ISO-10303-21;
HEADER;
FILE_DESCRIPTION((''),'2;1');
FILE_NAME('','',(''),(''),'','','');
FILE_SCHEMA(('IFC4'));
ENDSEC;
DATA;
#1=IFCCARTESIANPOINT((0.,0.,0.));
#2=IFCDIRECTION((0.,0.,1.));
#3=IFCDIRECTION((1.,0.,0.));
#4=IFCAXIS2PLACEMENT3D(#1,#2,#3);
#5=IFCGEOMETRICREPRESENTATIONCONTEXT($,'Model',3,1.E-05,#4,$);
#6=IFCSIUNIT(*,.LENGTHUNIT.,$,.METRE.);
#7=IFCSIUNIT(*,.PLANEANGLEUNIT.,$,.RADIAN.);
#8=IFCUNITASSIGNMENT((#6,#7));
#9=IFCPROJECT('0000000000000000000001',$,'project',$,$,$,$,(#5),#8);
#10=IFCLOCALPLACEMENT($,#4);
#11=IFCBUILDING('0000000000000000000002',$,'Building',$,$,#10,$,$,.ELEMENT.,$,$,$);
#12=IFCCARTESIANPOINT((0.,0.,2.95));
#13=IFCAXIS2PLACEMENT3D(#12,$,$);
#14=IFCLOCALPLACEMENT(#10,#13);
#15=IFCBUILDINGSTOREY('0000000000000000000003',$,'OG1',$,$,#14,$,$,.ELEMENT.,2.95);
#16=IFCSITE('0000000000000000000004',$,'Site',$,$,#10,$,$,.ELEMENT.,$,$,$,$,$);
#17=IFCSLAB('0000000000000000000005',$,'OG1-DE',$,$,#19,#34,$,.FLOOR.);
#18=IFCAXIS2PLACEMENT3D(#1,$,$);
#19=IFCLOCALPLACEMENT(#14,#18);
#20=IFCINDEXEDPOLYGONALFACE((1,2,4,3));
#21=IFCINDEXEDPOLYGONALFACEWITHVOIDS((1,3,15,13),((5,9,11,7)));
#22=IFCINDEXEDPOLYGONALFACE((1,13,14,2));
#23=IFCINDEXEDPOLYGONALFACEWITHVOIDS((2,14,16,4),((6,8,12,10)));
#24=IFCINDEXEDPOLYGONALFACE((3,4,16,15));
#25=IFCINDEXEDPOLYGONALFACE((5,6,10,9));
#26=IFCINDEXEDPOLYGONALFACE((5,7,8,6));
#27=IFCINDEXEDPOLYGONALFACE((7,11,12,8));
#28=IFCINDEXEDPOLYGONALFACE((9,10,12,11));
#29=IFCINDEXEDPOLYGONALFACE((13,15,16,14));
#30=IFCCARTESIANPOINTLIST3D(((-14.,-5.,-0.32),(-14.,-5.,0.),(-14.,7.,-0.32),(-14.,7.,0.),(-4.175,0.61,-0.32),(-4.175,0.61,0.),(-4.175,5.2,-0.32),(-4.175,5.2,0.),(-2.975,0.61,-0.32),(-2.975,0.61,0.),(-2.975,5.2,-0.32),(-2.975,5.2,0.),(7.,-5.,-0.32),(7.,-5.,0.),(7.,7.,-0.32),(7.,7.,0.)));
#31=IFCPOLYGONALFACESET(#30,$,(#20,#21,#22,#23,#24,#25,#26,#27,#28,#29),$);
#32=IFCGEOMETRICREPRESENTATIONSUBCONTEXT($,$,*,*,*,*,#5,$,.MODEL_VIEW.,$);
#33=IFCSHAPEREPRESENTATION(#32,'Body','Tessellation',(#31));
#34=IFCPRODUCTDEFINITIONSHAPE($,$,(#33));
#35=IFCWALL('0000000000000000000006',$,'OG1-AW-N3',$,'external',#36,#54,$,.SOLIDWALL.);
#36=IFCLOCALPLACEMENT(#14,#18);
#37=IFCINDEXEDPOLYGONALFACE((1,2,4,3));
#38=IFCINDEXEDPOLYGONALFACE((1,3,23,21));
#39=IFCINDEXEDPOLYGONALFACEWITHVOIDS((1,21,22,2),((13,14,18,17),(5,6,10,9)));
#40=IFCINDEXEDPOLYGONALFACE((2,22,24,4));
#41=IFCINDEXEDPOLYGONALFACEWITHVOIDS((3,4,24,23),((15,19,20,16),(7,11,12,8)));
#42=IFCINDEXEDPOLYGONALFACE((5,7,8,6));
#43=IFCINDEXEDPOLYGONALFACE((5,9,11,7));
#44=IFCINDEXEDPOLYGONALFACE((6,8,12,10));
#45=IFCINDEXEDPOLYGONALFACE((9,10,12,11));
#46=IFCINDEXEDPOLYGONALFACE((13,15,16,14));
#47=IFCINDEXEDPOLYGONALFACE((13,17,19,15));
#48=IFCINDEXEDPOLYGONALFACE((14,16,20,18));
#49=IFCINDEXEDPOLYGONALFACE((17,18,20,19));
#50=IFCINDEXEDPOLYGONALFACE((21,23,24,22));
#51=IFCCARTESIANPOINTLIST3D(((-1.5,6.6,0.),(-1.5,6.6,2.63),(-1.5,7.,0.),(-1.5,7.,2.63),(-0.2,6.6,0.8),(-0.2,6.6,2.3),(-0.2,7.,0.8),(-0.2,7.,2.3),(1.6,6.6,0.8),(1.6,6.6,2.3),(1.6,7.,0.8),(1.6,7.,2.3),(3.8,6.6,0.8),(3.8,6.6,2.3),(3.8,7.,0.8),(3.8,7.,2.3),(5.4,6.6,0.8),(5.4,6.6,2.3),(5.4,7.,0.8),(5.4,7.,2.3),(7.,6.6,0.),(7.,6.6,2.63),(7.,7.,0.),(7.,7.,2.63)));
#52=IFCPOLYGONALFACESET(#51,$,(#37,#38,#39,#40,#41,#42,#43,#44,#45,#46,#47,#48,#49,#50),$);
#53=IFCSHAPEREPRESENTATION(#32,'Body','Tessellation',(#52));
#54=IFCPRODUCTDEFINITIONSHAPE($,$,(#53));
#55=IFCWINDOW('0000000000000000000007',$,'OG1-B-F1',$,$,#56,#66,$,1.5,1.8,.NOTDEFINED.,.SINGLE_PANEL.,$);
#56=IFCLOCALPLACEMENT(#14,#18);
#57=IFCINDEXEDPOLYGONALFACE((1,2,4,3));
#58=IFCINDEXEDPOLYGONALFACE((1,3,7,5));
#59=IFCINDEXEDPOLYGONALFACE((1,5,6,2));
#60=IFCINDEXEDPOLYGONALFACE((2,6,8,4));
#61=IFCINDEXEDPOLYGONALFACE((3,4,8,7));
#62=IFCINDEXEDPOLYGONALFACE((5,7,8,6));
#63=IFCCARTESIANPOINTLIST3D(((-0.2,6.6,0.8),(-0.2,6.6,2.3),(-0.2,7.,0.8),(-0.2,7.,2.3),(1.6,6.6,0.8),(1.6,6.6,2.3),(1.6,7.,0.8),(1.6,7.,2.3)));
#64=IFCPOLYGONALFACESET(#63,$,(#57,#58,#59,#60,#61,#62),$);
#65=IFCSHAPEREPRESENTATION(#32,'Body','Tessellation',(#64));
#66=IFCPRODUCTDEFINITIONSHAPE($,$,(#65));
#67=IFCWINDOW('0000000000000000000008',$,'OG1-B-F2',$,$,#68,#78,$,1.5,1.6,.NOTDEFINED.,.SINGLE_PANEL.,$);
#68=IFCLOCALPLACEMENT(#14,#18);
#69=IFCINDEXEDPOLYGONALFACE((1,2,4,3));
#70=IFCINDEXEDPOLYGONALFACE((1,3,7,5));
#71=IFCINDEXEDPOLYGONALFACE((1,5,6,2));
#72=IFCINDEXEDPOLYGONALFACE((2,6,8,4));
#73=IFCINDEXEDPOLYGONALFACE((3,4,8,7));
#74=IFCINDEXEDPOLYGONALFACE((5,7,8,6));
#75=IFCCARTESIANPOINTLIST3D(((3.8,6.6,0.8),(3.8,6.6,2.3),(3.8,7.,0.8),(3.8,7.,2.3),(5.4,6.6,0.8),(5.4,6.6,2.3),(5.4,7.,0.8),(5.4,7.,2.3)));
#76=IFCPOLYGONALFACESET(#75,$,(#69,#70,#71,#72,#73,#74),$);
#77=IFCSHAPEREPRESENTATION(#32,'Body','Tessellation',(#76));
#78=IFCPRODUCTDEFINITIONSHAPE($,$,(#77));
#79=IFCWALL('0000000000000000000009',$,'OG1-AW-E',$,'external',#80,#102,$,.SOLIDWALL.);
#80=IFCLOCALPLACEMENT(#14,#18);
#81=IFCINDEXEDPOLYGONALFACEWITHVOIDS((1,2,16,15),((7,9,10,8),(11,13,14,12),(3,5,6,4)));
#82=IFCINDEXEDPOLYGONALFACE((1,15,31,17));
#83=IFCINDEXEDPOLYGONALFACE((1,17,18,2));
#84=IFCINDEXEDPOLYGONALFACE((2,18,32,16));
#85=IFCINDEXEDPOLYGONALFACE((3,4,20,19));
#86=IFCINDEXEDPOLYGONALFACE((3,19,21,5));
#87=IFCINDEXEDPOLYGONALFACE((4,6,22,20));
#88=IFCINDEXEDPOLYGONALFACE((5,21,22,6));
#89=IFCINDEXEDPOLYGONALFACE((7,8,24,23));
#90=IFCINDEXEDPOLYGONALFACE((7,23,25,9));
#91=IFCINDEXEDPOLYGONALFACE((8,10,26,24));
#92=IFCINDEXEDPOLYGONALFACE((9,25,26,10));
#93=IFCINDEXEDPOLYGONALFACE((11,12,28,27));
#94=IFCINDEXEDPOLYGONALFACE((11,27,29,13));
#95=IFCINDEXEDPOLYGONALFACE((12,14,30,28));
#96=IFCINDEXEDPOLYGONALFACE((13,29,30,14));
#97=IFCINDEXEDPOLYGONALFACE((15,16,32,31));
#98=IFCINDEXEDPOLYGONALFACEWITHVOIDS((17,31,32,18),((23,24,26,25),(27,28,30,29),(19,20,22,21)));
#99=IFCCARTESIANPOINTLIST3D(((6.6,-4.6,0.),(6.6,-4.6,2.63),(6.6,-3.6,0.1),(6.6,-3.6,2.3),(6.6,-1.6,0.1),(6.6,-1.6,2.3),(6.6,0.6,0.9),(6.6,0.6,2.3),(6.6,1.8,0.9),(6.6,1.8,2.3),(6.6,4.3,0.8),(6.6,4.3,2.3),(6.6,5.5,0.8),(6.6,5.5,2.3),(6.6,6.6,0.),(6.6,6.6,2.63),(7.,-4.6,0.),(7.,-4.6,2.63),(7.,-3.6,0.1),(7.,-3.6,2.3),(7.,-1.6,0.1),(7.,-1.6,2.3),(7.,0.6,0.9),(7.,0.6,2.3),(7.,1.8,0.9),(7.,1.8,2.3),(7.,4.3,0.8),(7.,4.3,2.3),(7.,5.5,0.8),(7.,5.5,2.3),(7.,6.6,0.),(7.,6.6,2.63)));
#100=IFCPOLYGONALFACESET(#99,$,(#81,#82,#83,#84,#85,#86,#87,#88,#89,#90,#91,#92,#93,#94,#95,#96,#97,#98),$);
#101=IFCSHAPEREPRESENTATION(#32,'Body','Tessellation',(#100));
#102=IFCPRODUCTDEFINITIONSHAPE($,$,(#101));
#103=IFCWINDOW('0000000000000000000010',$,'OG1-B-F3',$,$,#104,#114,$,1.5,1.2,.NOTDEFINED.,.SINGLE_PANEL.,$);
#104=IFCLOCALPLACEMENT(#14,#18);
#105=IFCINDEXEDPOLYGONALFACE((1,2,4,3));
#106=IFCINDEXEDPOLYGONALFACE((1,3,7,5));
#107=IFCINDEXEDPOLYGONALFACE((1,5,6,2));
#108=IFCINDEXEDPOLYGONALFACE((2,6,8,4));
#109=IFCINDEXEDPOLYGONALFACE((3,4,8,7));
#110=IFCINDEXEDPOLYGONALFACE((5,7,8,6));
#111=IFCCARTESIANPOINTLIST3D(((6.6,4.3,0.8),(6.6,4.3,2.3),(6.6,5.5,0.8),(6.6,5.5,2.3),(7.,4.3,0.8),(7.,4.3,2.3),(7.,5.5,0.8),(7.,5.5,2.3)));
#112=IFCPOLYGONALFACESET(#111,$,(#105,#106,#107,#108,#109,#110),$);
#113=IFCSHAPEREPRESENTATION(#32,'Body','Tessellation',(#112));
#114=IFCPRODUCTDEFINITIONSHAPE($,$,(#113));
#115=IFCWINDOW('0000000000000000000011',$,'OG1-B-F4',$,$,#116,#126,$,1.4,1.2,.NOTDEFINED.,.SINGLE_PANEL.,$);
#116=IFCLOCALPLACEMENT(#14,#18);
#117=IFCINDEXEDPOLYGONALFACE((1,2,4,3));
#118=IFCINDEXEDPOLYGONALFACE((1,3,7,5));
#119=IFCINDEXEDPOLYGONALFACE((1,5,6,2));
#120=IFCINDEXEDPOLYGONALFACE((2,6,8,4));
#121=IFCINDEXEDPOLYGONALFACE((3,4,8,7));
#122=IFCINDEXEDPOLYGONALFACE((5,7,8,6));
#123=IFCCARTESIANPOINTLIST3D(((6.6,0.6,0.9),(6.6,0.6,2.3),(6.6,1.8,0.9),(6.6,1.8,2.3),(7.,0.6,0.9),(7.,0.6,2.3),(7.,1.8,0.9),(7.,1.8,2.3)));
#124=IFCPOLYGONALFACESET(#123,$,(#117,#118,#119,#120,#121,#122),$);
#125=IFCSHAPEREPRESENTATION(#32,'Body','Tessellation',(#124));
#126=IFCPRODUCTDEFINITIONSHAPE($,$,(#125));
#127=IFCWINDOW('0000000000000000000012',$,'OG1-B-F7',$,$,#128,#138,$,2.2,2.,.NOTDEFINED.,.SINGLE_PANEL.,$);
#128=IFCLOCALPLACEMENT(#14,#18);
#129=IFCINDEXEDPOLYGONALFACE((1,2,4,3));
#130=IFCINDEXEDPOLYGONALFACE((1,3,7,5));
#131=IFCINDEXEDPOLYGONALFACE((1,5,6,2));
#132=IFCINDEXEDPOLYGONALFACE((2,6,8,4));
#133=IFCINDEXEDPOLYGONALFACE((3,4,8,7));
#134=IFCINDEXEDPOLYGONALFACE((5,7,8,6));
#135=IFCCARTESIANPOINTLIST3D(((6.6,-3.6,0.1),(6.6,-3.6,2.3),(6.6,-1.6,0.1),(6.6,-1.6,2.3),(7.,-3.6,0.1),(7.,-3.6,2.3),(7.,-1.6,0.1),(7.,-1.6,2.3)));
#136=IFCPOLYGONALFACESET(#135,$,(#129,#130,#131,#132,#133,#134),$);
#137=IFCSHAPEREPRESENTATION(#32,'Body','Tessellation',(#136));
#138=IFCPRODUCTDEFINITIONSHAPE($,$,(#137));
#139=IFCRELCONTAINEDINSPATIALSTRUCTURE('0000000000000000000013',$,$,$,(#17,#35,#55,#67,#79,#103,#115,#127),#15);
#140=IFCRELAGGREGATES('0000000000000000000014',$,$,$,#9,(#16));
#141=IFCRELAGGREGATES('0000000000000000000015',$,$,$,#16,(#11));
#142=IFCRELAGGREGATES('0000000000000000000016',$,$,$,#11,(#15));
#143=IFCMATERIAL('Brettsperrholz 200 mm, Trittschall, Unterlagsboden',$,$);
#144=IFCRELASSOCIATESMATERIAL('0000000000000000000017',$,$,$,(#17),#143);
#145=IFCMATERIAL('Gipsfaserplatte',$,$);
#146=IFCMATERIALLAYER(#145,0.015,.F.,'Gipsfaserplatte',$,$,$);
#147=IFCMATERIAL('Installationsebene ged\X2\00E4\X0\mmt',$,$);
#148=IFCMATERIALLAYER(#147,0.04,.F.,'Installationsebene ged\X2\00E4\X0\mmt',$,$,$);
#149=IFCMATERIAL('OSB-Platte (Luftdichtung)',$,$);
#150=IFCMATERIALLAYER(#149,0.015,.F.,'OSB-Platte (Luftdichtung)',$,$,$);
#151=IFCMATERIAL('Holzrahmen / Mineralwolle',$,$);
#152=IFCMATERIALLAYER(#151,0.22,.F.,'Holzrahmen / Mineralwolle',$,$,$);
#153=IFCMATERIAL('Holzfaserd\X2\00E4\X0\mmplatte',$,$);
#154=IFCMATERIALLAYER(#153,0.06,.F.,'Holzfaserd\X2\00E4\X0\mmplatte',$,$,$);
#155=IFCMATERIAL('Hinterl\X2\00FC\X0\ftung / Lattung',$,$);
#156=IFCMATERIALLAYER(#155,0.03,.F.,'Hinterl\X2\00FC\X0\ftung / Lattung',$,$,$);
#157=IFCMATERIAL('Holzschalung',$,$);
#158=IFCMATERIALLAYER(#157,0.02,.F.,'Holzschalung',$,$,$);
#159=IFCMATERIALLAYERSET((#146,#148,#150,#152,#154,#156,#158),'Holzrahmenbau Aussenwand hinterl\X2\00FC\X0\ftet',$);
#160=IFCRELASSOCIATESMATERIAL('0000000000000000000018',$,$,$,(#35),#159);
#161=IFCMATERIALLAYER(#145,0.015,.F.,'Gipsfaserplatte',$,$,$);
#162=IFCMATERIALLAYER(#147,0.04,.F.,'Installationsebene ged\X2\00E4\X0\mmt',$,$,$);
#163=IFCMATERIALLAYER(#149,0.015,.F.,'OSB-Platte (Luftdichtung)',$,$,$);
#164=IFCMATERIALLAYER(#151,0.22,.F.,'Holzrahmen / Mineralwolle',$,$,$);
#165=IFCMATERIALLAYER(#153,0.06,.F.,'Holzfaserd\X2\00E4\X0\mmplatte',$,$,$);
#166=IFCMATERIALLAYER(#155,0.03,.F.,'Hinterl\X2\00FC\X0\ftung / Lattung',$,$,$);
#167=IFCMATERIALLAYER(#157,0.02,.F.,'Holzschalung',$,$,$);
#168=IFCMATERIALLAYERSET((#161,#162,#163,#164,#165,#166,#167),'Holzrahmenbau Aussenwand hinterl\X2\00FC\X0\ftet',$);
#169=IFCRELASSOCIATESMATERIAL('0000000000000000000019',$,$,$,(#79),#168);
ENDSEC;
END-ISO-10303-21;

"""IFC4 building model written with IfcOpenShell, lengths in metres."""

from ifc_helpers import new_model, si_unit, frame, frame_2d, origin, origin_with_axes, origin_2d, place, context, subcontext, project, spatial, polyline, rectangle, outline, extrude, material, layer, layer_set, element, fill, save


model = new_model("IFC4")

# Units and contexts
model_context = context("Model", 3, precision=1e-05, world=origin_with_axes())
sub_context = subcontext(model_context, None, None, "MODEL_VIEW")
ifc_project = project(units=[si_unit("LENGTHUNIT", "METRE"), si_unit("PLANEANGLEUNIT", "RADIAN")], contexts=[model_context])

# Site, building, storey
placement = place(None, origin_with_axes())
site = spatial("IfcSite", under=ifc_project, at=placement, Name="Site", CompositionType="ELEMENT")
building = spatial("IfcBuilding", under=site, at=placement, Name="Building", CompositionType="ELEMENT")
storey_placement = place(placement, frame((0.0, 0.0, 2.95)))
storey = spatial("IfcBuildingStorey", under=building, at=storey_placement, Name="OG1", CompositionType="ELEMENT", Elevation=2.95)

# Slab, opening
ifc_material_1 = material(Name="Brettsperrholz 200 mm, Trittschall, Unterlagsboden")
slab_placement = place(storey_placement, frame((0.0, 0.0, -0.32)))
slab = element("IfcSlab", 1, at=slab_placement, inside=storey, material=ifc_material_1, Name="OG1-DE", PredefinedType="FLOOR", context=sub_context, shape_type="SweptSolid", body=[
    extrude(outline(polyline([(-14.0, -5.0), (7.0, -5.0), (7.0, 7.0), (-14.0, 7.0), (-14.0, -5.0)])), origin(), (0.0, 0.0, 1.0), 0.32),
])
opening_1_placement = place(slab_placement, frame((-3.575, 2.905, 0.0)))
element("IfcOpeningElement", 2, at=opening_1_placement, cuts=slab, PredefinedType="OPENING", context=sub_context, shape_type="SweptSolid", body=[
    extrude(rectangle(XDim=1.2, YDim=4.59, at=origin_2d()), origin(), (0.0, 0.0, 1.0), 0.42),
])

# Walls, openings, windows
ifc_material_2 = material(Name="Gipsfaserplatte")
ifc_layer_1 = layer(ifc_material_2, 0.015, ventilated=False, Name="Gipsfaserplatte")
ifc_material_3 = material(Name="Installationsebene gedämmt")
ifc_layer_2 = layer(ifc_material_3, 0.04, ventilated=False, Name="Installationsebene gedämmt")
ifc_material_4 = material(Name="OSB-Platte (Luftdichtung)")
ifc_layer_3 = layer(ifc_material_4, 0.015, ventilated=False, Name="OSB-Platte (Luftdichtung)")
ifc_material_5 = material(Name="Holzrahmen / Mineralwolle")
ifc_layer_4 = layer(ifc_material_5, 0.22, ventilated=False, Name="Holzrahmen / Mineralwolle")
ifc_material_6 = material(Name="Holzfaserdämmplatte")
ifc_layer_5 = layer(ifc_material_6, 0.06, ventilated=False, Name="Holzfaserdämmplatte")
ifc_material_7 = material(Name="Hinterlüftung / Lattung")
ifc_layer_6 = layer(ifc_material_7, 0.03, ventilated=False, Name="Hinterlüftung / Lattung")
ifc_material_8 = material(Name="Holzschalung")
ifc_layer_7 = layer(ifc_material_8, 0.02, ventilated=False, Name="Holzschalung")
ifc_layer_set_1 = layer_set([ifc_layer_1, ifc_layer_2, ifc_layer_3, ifc_layer_4, ifc_layer_5, ifc_layer_6, ifc_layer_7], Name="Holzrahmenbau Aussenwand hinterlüftet")
wall_1_placement = place(storey_placement, frame((-1.5, 6.8, 0.0), z_axis=(0.0, 0.0, 1.0), x_axis=(1.0, 0.0, 0.0)))
wall_1 = element("IfcWall", 3, at=wall_1_placement, inside=storey, material=ifc_layer_set_1, Name="OG1-AW-N3", ObjectType="external", PredefinedType="SOLIDWALL", context=sub_context, shape_type="SweptSolid", body=[
    extrude(rectangle(XDim=8.5, YDim=0.4, at=frame_2d((4.25, 0.0))), origin(), (0.0, 0.0, 1.0), 2.63),
])
opening_2_placement = place(wall_1_placement, frame((2.2, 0.25, 0.8), z_axis=(0.0, -1.0, 0.0), x_axis=(1.0, 0.0, 0.0)))
opening_2 = element("IfcOpeningElement", 4, at=opening_2_placement, cuts=wall_1, PredefinedType="OPENING", context=sub_context, shape_type="SweptSolid", body=[
    extrude(rectangle(XDim=1.8, YDim=1.5, at=frame_2d((0.0, 0.75))), origin(), (0.0, 0.0, 1.0), 0.5),
])
opening_3_placement = place(wall_1_placement, frame((6.1, 0.25, 0.8), z_axis=(0.0, -1.0, 0.0), x_axis=(1.0, 0.0, 0.0)))
opening_3 = element("IfcOpeningElement", 5, at=opening_3_placement, cuts=wall_1, PredefinedType="OPENING", context=sub_context, shape_type="SweptSolid", body=[
    extrude(rectangle(XDim=1.6, YDim=1.5, at=frame_2d((0.0, 0.75))), origin(), (0.0, 0.0, 1.0), 0.5),
])
window_1_placement = place(wall_1_placement, frame((2.2, 0.2, 0.8), z_axis=(0.0, -1.0, 0.0), x_axis=(1.0, 0.0, 0.0)))
window_1 = element("IfcWindow", 6, at=window_1_placement, inside=storey, Name="OG1-B-F1", OverallHeight=1.5, OverallWidth=1.8, PartitioningType="SINGLE_PANEL", PredefinedType="NOTDEFINED", context=sub_context, shape_type="SweptSolid", body=[
    extrude(rectangle(XDim=1.8, YDim=1.5, at=frame_2d((0.0, 0.75))), origin(), (0.0, 0.0, 1.0), 0.4),
])
fill(opening_2, window_1)
window_2_placement = place(wall_1_placement, frame((6.1, 0.2, 0.8), z_axis=(0.0, -1.0, 0.0), x_axis=(1.0, 0.0, 0.0)))
window_2 = element("IfcWindow", 7, at=window_2_placement, inside=storey, Name="OG1-B-F2", OverallHeight=1.5, OverallWidth=1.6, PartitioningType="SINGLE_PANEL", PredefinedType="NOTDEFINED", context=sub_context, shape_type="SweptSolid", body=[
    extrude(rectangle(XDim=1.6, YDim=1.5, at=frame_2d((0.0, 0.75))), origin(), (0.0, 0.0, 1.0), 0.4),
])
fill(opening_3, window_2)
ifc_layer_8 = layer(ifc_material_2, 0.015, ventilated=False, Name="Gipsfaserplatte")
ifc_layer_9 = layer(ifc_material_3, 0.04, ventilated=False, Name="Installationsebene gedämmt")
ifc_layer_10 = layer(ifc_material_4, 0.015, ventilated=False, Name="OSB-Platte (Luftdichtung)")
ifc_layer_11 = layer(ifc_material_5, 0.22, ventilated=False, Name="Holzrahmen / Mineralwolle")
ifc_layer_12 = layer(ifc_material_6, 0.06, ventilated=False, Name="Holzfaserdämmplatte")
ifc_layer_13 = layer(ifc_material_7, 0.03, ventilated=False, Name="Hinterlüftung / Lattung")
ifc_layer_14 = layer(ifc_material_8, 0.02, ventilated=False, Name="Holzschalung")
ifc_layer_set_2 = layer_set([ifc_layer_8, ifc_layer_9, ifc_layer_10, ifc_layer_11, ifc_layer_12, ifc_layer_13, ifc_layer_14], Name="Holzrahmenbau Aussenwand hinterlüftet")
wall_2_placement = place(storey_placement, frame((6.8, 6.6, 0.0), z_axis=(0.0, 0.0, 1.0), x_axis=(0.0, -1.0, 0.0)))
wall_2 = element("IfcWall", 8, at=wall_2_placement, inside=storey, material=ifc_layer_set_2, Name="OG1-AW-E", ObjectType="external", PredefinedType="SOLIDWALL", context=sub_context, shape_type="SweptSolid", body=[
    extrude(rectangle(XDim=11.2, YDim=0.4, at=frame_2d((5.6, 0.0))), origin(), (0.0, 0.0, 1.0), 2.63),
])
opening_4_placement = place(wall_2_placement, frame((1.7, 0.25, 0.8), z_axis=(0.0, -1.0, 0.0), x_axis=(1.0, 0.0, 0.0)))
opening_4 = element("IfcOpeningElement", 9, at=opening_4_placement, cuts=wall_2, PredefinedType="OPENING", context=sub_context, shape_type="SweptSolid", body=[
    extrude(rectangle(XDim=1.2, YDim=1.5, at=frame_2d((0.0, 0.75))), origin(), (0.0, 0.0, 1.0), 0.5),
])
opening_5_placement = place(wall_2_placement, frame((5.4, 0.25, 0.9), z_axis=(0.0, -1.0, 0.0), x_axis=(1.0, 0.0, 0.0)))
opening_5 = element("IfcOpeningElement", 10, at=opening_5_placement, cuts=wall_2, PredefinedType="OPENING", context=sub_context, shape_type="SweptSolid", body=[
    extrude(rectangle(XDim=1.2, YDim=1.4, at=frame_2d((0.0, 0.7))), origin(), (0.0, 0.0, 1.0), 0.5),
])
opening_6_placement = place(wall_2_placement, frame((9.2, 0.25, 0.1), z_axis=(0.0, -1.0, 0.0), x_axis=(1.0, 0.0, 0.0)))
opening_6 = element("IfcOpeningElement", 11, at=opening_6_placement, cuts=wall_2, PredefinedType="OPENING", context=sub_context, shape_type="SweptSolid", body=[
    extrude(rectangle(XDim=2.0, YDim=2.2, at=frame_2d((0.0, 1.1))), origin(), (0.0, 0.0, 1.0), 0.5),
])
window_3_placement = place(wall_2_placement, frame((1.7, 0.2, 0.8), z_axis=(0.0, -1.0, 0.0), x_axis=(1.0, 0.0, 0.0)))
window_3 = element("IfcWindow", 12, at=window_3_placement, inside=storey, Name="OG1-B-F3", OverallHeight=1.5, OverallWidth=1.2, PartitioningType="SINGLE_PANEL", PredefinedType="NOTDEFINED", context=sub_context, shape_type="SweptSolid", body=[
    extrude(rectangle(XDim=1.2, YDim=1.5, at=frame_2d((0.0, 0.75))), origin(), (0.0, 0.0, 1.0), 0.4),
])
fill(opening_4, window_3)
window_4_placement = place(wall_2_placement, frame((5.4, 0.2, 0.9), z_axis=(0.0, -1.0, 0.0), x_axis=(1.0, 0.0, 0.0)))
window_4 = element("IfcWindow", 13, at=window_4_placement, inside=storey, Name="OG1-B-F4", OverallHeight=1.4, OverallWidth=1.2, PartitioningType="SINGLE_PANEL", PredefinedType="NOTDEFINED", context=sub_context, shape_type="SweptSolid", body=[
    extrude(rectangle(XDim=1.2, YDim=1.4, at=frame_2d((0.0, 0.7))), origin(), (0.0, 0.0, 1.0), 0.4),
])
fill(opening_5, window_4)
window_5_placement = place(wall_2_placement, frame((9.2, 0.2, 0.1), z_axis=(0.0, -1.0, 0.0), x_axis=(1.0, 0.0, 0.0)))
window_5 = element("IfcWindow", 14, at=window_5_placement, inside=storey, Name="OG1-B-F7", OverallHeight=2.2, OverallWidth=2.0, PartitioningType="SINGLE_PANEL", PredefinedType="NOTDEFINED", context=sub_context, shape_type="SweptSolid", body=[
    extrude(rectangle(XDim=2.0, YDim=2.2, at=frame_2d((0.0, 1.1))), origin(), (0.0, 0.0, 1.0), 0.4),
])
fill(opening_6, window_5)

save(model, "model.ifc")
